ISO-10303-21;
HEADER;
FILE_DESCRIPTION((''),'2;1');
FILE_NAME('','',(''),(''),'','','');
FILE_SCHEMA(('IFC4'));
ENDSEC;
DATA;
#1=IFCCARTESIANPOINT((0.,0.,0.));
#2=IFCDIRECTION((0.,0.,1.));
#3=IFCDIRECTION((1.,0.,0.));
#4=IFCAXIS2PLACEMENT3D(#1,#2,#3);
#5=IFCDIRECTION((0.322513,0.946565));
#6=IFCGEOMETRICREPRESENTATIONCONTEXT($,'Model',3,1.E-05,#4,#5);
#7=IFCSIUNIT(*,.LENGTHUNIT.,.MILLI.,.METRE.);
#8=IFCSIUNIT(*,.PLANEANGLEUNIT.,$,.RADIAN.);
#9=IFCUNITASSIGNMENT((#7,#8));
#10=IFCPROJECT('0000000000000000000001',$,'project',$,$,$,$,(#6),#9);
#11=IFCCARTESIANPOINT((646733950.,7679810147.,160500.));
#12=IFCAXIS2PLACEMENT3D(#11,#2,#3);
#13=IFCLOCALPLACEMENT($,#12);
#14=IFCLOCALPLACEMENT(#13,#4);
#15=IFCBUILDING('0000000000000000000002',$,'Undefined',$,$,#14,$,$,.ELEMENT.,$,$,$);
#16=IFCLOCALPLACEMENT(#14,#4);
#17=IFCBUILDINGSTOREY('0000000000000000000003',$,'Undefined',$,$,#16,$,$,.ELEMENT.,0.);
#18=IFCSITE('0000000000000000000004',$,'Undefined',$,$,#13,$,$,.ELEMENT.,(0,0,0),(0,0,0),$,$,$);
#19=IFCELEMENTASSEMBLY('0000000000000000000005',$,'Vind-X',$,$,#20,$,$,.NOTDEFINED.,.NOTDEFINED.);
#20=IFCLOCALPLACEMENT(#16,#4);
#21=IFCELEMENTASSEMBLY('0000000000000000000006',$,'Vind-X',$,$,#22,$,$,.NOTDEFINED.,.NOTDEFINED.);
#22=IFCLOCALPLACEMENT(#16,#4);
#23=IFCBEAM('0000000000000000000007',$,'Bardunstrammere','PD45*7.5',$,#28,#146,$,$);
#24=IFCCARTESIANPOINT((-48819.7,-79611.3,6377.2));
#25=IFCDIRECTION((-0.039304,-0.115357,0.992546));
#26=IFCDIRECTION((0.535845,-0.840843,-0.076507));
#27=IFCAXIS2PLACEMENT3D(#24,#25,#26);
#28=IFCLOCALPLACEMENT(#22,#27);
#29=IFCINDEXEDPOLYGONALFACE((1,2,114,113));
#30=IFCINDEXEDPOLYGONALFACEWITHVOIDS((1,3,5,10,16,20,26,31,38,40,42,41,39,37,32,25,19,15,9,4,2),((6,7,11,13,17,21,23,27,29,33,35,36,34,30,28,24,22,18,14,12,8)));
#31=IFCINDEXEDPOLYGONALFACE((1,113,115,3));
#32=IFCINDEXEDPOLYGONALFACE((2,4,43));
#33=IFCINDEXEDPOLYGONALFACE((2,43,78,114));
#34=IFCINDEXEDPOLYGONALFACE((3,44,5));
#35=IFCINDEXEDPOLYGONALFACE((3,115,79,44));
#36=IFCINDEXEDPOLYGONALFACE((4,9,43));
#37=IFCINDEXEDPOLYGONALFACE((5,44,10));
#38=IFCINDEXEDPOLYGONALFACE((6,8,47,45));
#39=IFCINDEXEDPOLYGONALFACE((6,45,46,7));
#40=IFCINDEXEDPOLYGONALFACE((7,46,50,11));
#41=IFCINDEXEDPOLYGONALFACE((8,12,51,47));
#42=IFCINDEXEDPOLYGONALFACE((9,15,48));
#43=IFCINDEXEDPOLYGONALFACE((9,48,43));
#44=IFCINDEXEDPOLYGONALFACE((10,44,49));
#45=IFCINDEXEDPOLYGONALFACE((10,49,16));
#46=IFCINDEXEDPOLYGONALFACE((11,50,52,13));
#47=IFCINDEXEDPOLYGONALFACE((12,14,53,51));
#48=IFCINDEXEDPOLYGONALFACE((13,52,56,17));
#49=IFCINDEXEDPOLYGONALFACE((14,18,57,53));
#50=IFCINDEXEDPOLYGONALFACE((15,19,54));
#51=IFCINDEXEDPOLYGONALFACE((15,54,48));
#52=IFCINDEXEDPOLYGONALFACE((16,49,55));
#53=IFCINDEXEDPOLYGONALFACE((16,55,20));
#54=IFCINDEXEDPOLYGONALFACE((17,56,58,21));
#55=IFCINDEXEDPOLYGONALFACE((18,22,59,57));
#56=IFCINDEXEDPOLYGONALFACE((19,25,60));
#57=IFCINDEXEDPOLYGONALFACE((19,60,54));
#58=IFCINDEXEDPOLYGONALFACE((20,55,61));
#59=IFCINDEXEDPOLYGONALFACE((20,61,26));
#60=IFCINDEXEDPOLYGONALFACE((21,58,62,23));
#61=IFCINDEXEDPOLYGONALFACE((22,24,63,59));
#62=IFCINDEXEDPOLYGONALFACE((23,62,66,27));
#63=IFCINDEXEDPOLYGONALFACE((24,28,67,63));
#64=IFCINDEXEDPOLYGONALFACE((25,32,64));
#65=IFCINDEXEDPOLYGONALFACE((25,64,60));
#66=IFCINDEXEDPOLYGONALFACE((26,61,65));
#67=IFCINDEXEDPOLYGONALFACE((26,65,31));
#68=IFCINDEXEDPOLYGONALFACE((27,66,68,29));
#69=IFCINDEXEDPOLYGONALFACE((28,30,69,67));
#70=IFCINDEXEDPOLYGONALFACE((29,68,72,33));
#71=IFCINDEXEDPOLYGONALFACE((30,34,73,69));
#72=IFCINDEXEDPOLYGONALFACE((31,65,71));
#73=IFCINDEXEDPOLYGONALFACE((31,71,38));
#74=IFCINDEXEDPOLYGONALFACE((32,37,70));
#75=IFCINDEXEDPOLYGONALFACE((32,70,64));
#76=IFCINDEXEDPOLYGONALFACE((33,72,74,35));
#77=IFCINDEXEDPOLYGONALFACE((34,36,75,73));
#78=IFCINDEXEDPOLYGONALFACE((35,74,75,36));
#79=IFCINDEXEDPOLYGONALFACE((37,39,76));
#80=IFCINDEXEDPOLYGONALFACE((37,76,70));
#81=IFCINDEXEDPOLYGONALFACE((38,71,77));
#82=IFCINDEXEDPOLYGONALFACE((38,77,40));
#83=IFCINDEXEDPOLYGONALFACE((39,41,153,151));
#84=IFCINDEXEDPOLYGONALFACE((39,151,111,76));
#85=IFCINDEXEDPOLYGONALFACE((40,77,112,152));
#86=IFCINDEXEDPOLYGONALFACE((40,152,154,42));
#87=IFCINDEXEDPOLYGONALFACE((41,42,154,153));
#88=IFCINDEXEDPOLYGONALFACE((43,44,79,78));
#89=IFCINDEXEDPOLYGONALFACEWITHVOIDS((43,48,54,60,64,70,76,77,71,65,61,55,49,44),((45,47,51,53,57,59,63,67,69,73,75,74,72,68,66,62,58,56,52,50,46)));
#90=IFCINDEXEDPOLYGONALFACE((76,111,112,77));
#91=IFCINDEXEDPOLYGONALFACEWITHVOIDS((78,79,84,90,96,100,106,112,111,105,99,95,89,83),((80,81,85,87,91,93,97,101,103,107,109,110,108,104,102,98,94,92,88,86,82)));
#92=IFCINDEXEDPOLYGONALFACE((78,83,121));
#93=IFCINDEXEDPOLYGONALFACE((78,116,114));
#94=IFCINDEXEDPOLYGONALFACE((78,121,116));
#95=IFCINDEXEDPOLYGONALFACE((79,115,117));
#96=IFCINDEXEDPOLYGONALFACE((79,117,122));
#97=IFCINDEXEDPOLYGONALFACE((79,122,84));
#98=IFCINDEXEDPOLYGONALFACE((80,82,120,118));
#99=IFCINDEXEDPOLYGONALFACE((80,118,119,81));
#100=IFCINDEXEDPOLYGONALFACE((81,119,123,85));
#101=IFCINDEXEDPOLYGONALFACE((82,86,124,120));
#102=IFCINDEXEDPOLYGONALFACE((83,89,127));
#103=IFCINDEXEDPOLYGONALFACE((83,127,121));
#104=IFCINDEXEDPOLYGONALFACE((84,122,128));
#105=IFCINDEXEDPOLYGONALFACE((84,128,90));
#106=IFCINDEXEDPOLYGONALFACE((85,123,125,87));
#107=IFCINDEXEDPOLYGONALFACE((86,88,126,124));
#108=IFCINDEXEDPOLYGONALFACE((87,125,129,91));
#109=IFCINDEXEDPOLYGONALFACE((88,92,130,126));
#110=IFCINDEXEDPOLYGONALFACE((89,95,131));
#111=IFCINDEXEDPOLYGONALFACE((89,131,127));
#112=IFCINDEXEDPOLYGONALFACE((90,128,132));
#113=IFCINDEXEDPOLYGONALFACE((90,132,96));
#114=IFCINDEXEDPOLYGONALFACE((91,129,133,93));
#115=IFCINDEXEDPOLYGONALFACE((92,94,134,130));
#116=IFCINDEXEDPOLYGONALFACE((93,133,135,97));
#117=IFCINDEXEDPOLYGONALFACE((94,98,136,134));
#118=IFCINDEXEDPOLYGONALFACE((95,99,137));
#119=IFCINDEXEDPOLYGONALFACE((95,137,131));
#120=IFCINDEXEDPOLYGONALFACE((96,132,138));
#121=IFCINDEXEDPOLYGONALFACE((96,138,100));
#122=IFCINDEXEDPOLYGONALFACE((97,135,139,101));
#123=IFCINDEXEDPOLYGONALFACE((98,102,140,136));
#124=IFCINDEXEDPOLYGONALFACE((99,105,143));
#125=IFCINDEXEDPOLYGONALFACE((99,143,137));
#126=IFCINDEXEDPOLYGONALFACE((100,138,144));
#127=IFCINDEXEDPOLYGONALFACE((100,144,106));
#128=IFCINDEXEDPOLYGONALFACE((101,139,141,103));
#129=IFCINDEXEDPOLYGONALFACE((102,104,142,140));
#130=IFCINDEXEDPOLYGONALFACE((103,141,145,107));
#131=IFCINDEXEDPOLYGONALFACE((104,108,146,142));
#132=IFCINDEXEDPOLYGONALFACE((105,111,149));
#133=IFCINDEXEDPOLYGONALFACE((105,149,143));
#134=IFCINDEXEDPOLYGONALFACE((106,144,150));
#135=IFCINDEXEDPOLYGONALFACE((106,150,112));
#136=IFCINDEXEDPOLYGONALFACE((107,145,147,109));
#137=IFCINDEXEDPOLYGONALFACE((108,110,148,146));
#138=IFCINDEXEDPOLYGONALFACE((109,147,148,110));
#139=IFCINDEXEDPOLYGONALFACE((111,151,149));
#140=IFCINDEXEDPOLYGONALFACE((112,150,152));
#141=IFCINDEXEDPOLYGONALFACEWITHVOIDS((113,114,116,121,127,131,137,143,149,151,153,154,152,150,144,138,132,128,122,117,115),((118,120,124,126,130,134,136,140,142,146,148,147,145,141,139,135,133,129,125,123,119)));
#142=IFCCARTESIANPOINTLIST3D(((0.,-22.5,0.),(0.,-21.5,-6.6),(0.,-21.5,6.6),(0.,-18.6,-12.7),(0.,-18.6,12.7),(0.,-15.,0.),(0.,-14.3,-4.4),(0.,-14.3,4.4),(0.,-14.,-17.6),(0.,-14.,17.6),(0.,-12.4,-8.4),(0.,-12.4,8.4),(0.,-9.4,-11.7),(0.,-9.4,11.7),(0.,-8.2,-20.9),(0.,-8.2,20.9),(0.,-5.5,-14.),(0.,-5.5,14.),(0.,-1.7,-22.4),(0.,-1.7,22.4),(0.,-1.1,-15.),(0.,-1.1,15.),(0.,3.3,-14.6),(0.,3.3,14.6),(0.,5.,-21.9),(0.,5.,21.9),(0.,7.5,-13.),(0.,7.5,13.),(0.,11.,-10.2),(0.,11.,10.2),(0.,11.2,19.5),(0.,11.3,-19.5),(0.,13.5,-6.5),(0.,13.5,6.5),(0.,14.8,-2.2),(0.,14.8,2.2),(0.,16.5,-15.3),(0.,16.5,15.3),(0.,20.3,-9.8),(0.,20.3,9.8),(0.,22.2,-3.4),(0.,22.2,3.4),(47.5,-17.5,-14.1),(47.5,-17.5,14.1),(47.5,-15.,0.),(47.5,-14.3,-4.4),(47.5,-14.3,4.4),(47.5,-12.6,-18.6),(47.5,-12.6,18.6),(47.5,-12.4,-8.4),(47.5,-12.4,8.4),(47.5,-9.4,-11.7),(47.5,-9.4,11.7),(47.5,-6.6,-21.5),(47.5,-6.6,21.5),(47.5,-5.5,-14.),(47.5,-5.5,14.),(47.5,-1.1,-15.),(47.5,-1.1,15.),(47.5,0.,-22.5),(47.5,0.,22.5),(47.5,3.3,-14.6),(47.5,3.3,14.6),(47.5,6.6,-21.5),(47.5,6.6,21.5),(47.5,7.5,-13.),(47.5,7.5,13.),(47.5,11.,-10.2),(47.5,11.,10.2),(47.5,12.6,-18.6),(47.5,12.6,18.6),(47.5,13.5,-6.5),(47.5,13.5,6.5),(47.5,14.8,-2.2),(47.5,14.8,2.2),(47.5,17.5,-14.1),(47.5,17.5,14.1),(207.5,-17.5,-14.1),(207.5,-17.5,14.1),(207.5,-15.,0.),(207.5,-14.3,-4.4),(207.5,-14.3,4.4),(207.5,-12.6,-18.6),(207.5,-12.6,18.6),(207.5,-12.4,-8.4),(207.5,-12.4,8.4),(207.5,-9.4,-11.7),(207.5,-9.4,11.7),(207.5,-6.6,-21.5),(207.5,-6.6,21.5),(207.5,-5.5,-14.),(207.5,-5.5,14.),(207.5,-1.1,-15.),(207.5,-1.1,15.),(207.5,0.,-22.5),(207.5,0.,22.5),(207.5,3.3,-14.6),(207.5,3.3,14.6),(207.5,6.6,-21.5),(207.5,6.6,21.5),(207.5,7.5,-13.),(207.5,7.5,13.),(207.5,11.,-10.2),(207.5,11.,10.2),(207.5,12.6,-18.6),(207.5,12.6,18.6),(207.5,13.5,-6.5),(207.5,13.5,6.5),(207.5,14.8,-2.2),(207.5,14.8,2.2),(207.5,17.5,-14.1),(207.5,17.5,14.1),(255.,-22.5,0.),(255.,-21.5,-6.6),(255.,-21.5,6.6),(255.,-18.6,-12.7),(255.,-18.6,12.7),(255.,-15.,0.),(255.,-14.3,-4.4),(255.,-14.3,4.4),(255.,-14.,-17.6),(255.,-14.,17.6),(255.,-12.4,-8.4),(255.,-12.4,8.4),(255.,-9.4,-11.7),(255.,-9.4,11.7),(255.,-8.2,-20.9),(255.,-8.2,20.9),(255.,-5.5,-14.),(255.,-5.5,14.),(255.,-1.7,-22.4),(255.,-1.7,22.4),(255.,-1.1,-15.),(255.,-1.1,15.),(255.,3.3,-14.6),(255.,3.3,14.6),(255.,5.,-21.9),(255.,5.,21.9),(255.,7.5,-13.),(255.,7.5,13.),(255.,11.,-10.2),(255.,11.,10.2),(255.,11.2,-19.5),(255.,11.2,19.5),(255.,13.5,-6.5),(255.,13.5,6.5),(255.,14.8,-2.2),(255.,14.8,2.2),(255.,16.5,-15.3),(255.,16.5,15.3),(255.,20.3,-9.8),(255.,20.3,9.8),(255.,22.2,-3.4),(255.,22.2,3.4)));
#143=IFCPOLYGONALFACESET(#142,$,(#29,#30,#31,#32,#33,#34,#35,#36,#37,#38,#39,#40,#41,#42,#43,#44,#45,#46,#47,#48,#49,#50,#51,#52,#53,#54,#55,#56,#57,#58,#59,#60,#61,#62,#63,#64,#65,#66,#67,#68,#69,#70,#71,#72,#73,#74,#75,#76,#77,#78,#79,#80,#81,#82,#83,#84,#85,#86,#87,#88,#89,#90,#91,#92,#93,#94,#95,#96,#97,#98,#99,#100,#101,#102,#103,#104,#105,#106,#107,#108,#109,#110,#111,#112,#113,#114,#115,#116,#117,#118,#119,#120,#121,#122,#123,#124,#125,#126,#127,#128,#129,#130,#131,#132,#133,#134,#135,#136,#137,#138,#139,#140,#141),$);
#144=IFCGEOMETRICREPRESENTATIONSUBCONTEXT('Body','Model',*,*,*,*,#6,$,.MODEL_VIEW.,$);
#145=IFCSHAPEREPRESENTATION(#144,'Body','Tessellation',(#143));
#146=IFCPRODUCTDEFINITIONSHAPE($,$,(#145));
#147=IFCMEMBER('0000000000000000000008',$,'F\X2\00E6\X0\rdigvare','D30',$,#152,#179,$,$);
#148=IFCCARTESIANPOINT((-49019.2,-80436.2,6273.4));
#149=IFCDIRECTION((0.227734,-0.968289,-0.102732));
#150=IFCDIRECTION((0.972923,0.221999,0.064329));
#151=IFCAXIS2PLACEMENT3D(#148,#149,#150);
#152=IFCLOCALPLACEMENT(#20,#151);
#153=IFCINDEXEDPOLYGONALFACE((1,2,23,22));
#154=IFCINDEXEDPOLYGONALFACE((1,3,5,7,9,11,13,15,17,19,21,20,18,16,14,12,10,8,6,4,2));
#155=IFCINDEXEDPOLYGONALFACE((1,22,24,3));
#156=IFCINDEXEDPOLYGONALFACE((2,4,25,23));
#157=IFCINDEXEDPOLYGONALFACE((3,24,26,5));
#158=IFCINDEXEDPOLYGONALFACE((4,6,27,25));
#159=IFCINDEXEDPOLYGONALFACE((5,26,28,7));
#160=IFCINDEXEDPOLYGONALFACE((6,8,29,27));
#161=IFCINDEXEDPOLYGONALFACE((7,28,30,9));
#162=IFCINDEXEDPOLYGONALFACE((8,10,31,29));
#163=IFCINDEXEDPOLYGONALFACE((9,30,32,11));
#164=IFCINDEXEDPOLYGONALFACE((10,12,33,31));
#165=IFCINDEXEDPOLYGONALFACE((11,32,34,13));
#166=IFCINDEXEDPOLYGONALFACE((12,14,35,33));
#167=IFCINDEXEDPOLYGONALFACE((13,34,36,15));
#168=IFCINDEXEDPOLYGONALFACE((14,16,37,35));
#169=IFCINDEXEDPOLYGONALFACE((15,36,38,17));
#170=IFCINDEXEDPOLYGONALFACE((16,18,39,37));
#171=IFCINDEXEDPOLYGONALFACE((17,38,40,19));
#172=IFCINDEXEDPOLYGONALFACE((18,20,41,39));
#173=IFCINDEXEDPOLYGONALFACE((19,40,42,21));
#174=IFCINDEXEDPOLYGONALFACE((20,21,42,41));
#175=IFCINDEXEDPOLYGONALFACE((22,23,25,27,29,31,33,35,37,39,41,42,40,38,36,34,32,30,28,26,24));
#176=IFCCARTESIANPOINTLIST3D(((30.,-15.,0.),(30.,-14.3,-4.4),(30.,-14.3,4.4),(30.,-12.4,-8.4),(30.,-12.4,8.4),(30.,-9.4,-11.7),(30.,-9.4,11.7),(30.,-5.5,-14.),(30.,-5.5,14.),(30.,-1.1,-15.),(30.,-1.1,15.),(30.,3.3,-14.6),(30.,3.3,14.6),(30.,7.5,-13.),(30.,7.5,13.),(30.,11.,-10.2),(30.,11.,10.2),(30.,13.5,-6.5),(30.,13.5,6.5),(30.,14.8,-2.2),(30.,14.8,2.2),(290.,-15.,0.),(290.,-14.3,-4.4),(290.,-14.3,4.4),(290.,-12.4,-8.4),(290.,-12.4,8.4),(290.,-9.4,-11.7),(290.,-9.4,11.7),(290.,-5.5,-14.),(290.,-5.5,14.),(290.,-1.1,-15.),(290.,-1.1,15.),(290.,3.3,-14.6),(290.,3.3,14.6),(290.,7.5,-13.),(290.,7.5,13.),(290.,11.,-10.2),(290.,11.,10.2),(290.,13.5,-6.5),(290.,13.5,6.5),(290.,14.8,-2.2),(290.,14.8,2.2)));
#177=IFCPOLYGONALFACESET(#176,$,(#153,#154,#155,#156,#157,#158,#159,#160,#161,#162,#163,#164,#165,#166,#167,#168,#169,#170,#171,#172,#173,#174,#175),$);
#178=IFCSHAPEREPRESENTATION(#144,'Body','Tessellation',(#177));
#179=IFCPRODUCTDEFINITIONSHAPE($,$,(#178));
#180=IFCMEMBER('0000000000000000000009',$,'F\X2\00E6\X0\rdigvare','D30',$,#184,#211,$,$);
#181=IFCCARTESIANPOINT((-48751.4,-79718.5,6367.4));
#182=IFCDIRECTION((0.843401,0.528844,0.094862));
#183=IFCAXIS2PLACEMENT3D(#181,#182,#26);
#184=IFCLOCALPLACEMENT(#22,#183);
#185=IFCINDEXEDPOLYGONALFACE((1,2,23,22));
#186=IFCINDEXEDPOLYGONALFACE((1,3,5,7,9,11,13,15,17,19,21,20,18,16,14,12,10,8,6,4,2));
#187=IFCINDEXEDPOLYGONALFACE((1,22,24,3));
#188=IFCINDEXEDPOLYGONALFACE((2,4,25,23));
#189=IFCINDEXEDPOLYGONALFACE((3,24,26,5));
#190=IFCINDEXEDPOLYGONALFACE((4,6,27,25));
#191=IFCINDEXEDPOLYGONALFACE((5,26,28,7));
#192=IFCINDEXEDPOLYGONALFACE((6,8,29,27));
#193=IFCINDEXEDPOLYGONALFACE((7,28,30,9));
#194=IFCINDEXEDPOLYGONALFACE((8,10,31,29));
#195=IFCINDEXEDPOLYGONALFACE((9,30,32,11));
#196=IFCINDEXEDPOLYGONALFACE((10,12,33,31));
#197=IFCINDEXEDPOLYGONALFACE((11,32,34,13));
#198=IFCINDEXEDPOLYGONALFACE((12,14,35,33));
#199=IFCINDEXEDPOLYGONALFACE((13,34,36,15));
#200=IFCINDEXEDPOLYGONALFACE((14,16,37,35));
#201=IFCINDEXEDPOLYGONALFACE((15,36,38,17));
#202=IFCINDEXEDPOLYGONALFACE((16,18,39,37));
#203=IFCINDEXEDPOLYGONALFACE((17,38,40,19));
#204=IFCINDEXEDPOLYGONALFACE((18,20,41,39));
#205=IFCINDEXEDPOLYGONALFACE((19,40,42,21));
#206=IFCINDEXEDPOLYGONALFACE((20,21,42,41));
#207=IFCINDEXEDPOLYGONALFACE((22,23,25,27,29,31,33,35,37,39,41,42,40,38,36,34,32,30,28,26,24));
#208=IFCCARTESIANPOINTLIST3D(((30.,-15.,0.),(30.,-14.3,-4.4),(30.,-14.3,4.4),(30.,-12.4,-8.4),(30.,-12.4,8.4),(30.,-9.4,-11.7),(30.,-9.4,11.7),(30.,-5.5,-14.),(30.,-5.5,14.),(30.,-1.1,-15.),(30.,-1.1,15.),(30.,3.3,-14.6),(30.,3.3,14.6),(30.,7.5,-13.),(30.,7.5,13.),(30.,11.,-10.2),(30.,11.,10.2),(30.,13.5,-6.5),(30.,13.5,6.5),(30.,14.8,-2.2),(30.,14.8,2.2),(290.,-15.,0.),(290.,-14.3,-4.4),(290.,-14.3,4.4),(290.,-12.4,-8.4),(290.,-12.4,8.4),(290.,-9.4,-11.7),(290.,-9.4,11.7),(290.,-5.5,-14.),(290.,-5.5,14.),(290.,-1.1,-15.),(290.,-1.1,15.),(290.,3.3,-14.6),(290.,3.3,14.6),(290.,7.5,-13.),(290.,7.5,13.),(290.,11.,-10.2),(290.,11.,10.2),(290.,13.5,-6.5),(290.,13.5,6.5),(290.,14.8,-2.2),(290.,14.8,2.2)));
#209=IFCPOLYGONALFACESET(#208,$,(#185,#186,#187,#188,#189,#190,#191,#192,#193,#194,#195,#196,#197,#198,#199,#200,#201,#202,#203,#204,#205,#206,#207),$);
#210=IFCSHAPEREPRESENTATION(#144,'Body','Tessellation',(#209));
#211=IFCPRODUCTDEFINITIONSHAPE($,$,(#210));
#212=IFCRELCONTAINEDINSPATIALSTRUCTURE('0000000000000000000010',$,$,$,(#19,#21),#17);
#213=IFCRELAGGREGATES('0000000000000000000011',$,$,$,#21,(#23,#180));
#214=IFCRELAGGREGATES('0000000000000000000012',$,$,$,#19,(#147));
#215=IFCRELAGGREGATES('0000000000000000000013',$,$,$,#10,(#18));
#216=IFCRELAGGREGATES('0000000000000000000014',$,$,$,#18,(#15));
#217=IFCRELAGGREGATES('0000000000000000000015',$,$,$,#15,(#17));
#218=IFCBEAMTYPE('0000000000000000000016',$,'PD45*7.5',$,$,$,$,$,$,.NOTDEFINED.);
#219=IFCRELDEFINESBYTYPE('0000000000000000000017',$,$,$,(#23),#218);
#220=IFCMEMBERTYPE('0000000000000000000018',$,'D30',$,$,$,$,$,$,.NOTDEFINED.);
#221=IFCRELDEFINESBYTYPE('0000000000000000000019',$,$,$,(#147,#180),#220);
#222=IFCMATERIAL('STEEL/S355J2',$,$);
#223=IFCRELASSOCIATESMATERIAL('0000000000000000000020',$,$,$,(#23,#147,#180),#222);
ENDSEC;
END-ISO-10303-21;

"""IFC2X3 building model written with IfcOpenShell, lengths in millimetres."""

from ifc_helpers import new_model, si_unit, direction, frame, origin_with_axes, origin_2d_with_axis, place, context, subcontext, project, spatial, rectangle, circle, hollow_circle, extrude, boolean, clip, halfspace, material, type_object, element, aggregate, save


model = new_model("IFC2X3")

# Units and contexts
model_context = context("Model", 3, precision=1e-05, world=origin_with_axes(), true_north=direction((0.322513, 0.946565)))
body_context = subcontext(model_context, "Body", "Model", "MODEL_VIEW")
ifc_project = project(units=[si_unit("LENGTHUNIT", "METRE", prefix="MILLI"), si_unit("PLANEANGLEUNIT", "RADIAN")], contexts=[model_context])

# Site, building, storey
site_placement = place(None, frame((646733950.0, 7679810147.0, 160500.0), z_axis=(0.0, 0.0, 1.0), x_axis=(1.0, 0.0, 0.0)))
site = spatial("IfcSite", under=ifc_project, at=site_placement, Name="Undefined", CompositionType="ELEMENT", RefLatitude=(0, 0, 0), RefLongitude=(0, 0, 0))
building_placement = place(site_placement, origin_with_axes())
building = spatial("IfcBuilding", under=site, at=building_placement, Name="Undefined", CompositionType="ELEMENT")
storey_placement = place(building_placement, origin_with_axes())
storey = spatial("IfcBuildingStorey", under=building, at=storey_placement, Name="Undefined", CompositionType="ELEMENT", Elevation=0.0)

# Element assemblies, beam
assembly_1_placement = place(storey_placement, origin_with_axes())
assembly_1 = element("IfcElementAssembly", 1, at=assembly_1_placement, inside=storey, Name="Vind-X", AssemblyPlace="NOTDEFINED", PredefinedType="NOTDEFINED")
ifc_material_1 = material(Name="STEEL/S355J2")
beam_type_1 = type_object("IfcBeamType", Name="PD45*7.5", PredefinedType="NOTDEFINED")
assembly_2_placement = place(storey_placement, origin_with_axes())
assembly_2 = element("IfcElementAssembly", 2, at=assembly_2_placement, inside=storey, Name="Vind-X", AssemblyPlace="NOTDEFINED", PredefinedType="NOTDEFINED")
beam_1_placement = place(assembly_2_placement, frame((-48819.7, -79611.3, 6377.2), z_axis=(-0.039304, -0.115357, 0.992546), x_axis=(0.535845, -0.840843, -0.076507)))
beam_1 = element("IfcBeam", 3, at=beam_1_placement, type_object=beam_type_1, material=ifc_material_1, Name="Bardunstrammere", Description="PD45*7.5", context=body_context, shape_type="CSG", body=[
    boolean("DIFFERENCE", extrude(hollow_circle(Radius=22.5, WallThickness=7.5, at=origin_2d_with_axis()), frame((255.0, 0.0, 0.0), z_axis=(-1.0, 0.0, 0.0), x_axis=(0.0, -1.0, 0.0)), (0.0, 0.0, 1.0), 255.0), extrude(rectangle(XDim=35.0, YDim=90.0, at=origin_2d_with_axis()), frame((207.5, 0.0, 0.0), z_axis=(-1.0, 0.0, 0.0), x_axis=(0.0, -1.0, 0.0)), (0.0, 0.0, 1.0), 160.0)),
])

# Members
member_type = type_object("IfcMemberType", Name="D30", PredefinedType="NOTDEFINED")
member_1_placement = place(assembly_1_placement, frame((-49019.2, -80436.2, 6273.4), z_axis=(0.227734, -0.968289, -0.102732), x_axis=(0.972923, 0.221999, 0.064329)))
member_1 = element("IfcMember", 4, at=member_1_placement, type_object=member_type, material=ifc_material_1, Name="Færdigvare", Description="D30", context=body_context, shape_type="Clipping", body=[
    clip(extrude(circle(Radius=15.0, at=origin_2d_with_axis()), frame((290.0, 0.0, 0.0), z_axis=(-1.0, 0.0, 0.0), x_axis=(0.0, -1.0, 0.0)), (0.0, 0.0, 1.0), 290.0), halfspace(frame((30.0, 0.0, -15.0), z_axis=(1.0, 0.0, 0.0), x_axis=(0.0, -1.0, 0.0)), True)),
])
member_2_placement = place(assembly_2_placement, frame((-48751.4, -79718.5, 6367.4), z_axis=(0.843401, 0.528844, 0.094862), x_axis=(0.535845, -0.840843, -0.076507)))
member_2 = element("IfcMember", 5, at=member_2_placement, type_object=member_type, material=ifc_material_1, Name="Færdigvare", Description="D30", context=body_context, shape_type="Clipping", body=[
    clip(extrude(circle(Radius=15.0, at=origin_2d_with_axis()), frame((290.0, 0.0, 0.0), z_axis=(-1.0, 0.0, 0.0), x_axis=(0.0, -1.0, 0.0)), (0.0, 0.0, 1.0), 290.0), halfspace(frame((30.0, 0.0, -15.0), z_axis=(1.0, 0.0, 0.0), x_axis=(0.0, -1.0, 0.0)), True)),
])

aggregate(assembly_2, [beam_1, member_2])
aggregate(assembly_1, [member_1])

save(model, "model.ifc")
